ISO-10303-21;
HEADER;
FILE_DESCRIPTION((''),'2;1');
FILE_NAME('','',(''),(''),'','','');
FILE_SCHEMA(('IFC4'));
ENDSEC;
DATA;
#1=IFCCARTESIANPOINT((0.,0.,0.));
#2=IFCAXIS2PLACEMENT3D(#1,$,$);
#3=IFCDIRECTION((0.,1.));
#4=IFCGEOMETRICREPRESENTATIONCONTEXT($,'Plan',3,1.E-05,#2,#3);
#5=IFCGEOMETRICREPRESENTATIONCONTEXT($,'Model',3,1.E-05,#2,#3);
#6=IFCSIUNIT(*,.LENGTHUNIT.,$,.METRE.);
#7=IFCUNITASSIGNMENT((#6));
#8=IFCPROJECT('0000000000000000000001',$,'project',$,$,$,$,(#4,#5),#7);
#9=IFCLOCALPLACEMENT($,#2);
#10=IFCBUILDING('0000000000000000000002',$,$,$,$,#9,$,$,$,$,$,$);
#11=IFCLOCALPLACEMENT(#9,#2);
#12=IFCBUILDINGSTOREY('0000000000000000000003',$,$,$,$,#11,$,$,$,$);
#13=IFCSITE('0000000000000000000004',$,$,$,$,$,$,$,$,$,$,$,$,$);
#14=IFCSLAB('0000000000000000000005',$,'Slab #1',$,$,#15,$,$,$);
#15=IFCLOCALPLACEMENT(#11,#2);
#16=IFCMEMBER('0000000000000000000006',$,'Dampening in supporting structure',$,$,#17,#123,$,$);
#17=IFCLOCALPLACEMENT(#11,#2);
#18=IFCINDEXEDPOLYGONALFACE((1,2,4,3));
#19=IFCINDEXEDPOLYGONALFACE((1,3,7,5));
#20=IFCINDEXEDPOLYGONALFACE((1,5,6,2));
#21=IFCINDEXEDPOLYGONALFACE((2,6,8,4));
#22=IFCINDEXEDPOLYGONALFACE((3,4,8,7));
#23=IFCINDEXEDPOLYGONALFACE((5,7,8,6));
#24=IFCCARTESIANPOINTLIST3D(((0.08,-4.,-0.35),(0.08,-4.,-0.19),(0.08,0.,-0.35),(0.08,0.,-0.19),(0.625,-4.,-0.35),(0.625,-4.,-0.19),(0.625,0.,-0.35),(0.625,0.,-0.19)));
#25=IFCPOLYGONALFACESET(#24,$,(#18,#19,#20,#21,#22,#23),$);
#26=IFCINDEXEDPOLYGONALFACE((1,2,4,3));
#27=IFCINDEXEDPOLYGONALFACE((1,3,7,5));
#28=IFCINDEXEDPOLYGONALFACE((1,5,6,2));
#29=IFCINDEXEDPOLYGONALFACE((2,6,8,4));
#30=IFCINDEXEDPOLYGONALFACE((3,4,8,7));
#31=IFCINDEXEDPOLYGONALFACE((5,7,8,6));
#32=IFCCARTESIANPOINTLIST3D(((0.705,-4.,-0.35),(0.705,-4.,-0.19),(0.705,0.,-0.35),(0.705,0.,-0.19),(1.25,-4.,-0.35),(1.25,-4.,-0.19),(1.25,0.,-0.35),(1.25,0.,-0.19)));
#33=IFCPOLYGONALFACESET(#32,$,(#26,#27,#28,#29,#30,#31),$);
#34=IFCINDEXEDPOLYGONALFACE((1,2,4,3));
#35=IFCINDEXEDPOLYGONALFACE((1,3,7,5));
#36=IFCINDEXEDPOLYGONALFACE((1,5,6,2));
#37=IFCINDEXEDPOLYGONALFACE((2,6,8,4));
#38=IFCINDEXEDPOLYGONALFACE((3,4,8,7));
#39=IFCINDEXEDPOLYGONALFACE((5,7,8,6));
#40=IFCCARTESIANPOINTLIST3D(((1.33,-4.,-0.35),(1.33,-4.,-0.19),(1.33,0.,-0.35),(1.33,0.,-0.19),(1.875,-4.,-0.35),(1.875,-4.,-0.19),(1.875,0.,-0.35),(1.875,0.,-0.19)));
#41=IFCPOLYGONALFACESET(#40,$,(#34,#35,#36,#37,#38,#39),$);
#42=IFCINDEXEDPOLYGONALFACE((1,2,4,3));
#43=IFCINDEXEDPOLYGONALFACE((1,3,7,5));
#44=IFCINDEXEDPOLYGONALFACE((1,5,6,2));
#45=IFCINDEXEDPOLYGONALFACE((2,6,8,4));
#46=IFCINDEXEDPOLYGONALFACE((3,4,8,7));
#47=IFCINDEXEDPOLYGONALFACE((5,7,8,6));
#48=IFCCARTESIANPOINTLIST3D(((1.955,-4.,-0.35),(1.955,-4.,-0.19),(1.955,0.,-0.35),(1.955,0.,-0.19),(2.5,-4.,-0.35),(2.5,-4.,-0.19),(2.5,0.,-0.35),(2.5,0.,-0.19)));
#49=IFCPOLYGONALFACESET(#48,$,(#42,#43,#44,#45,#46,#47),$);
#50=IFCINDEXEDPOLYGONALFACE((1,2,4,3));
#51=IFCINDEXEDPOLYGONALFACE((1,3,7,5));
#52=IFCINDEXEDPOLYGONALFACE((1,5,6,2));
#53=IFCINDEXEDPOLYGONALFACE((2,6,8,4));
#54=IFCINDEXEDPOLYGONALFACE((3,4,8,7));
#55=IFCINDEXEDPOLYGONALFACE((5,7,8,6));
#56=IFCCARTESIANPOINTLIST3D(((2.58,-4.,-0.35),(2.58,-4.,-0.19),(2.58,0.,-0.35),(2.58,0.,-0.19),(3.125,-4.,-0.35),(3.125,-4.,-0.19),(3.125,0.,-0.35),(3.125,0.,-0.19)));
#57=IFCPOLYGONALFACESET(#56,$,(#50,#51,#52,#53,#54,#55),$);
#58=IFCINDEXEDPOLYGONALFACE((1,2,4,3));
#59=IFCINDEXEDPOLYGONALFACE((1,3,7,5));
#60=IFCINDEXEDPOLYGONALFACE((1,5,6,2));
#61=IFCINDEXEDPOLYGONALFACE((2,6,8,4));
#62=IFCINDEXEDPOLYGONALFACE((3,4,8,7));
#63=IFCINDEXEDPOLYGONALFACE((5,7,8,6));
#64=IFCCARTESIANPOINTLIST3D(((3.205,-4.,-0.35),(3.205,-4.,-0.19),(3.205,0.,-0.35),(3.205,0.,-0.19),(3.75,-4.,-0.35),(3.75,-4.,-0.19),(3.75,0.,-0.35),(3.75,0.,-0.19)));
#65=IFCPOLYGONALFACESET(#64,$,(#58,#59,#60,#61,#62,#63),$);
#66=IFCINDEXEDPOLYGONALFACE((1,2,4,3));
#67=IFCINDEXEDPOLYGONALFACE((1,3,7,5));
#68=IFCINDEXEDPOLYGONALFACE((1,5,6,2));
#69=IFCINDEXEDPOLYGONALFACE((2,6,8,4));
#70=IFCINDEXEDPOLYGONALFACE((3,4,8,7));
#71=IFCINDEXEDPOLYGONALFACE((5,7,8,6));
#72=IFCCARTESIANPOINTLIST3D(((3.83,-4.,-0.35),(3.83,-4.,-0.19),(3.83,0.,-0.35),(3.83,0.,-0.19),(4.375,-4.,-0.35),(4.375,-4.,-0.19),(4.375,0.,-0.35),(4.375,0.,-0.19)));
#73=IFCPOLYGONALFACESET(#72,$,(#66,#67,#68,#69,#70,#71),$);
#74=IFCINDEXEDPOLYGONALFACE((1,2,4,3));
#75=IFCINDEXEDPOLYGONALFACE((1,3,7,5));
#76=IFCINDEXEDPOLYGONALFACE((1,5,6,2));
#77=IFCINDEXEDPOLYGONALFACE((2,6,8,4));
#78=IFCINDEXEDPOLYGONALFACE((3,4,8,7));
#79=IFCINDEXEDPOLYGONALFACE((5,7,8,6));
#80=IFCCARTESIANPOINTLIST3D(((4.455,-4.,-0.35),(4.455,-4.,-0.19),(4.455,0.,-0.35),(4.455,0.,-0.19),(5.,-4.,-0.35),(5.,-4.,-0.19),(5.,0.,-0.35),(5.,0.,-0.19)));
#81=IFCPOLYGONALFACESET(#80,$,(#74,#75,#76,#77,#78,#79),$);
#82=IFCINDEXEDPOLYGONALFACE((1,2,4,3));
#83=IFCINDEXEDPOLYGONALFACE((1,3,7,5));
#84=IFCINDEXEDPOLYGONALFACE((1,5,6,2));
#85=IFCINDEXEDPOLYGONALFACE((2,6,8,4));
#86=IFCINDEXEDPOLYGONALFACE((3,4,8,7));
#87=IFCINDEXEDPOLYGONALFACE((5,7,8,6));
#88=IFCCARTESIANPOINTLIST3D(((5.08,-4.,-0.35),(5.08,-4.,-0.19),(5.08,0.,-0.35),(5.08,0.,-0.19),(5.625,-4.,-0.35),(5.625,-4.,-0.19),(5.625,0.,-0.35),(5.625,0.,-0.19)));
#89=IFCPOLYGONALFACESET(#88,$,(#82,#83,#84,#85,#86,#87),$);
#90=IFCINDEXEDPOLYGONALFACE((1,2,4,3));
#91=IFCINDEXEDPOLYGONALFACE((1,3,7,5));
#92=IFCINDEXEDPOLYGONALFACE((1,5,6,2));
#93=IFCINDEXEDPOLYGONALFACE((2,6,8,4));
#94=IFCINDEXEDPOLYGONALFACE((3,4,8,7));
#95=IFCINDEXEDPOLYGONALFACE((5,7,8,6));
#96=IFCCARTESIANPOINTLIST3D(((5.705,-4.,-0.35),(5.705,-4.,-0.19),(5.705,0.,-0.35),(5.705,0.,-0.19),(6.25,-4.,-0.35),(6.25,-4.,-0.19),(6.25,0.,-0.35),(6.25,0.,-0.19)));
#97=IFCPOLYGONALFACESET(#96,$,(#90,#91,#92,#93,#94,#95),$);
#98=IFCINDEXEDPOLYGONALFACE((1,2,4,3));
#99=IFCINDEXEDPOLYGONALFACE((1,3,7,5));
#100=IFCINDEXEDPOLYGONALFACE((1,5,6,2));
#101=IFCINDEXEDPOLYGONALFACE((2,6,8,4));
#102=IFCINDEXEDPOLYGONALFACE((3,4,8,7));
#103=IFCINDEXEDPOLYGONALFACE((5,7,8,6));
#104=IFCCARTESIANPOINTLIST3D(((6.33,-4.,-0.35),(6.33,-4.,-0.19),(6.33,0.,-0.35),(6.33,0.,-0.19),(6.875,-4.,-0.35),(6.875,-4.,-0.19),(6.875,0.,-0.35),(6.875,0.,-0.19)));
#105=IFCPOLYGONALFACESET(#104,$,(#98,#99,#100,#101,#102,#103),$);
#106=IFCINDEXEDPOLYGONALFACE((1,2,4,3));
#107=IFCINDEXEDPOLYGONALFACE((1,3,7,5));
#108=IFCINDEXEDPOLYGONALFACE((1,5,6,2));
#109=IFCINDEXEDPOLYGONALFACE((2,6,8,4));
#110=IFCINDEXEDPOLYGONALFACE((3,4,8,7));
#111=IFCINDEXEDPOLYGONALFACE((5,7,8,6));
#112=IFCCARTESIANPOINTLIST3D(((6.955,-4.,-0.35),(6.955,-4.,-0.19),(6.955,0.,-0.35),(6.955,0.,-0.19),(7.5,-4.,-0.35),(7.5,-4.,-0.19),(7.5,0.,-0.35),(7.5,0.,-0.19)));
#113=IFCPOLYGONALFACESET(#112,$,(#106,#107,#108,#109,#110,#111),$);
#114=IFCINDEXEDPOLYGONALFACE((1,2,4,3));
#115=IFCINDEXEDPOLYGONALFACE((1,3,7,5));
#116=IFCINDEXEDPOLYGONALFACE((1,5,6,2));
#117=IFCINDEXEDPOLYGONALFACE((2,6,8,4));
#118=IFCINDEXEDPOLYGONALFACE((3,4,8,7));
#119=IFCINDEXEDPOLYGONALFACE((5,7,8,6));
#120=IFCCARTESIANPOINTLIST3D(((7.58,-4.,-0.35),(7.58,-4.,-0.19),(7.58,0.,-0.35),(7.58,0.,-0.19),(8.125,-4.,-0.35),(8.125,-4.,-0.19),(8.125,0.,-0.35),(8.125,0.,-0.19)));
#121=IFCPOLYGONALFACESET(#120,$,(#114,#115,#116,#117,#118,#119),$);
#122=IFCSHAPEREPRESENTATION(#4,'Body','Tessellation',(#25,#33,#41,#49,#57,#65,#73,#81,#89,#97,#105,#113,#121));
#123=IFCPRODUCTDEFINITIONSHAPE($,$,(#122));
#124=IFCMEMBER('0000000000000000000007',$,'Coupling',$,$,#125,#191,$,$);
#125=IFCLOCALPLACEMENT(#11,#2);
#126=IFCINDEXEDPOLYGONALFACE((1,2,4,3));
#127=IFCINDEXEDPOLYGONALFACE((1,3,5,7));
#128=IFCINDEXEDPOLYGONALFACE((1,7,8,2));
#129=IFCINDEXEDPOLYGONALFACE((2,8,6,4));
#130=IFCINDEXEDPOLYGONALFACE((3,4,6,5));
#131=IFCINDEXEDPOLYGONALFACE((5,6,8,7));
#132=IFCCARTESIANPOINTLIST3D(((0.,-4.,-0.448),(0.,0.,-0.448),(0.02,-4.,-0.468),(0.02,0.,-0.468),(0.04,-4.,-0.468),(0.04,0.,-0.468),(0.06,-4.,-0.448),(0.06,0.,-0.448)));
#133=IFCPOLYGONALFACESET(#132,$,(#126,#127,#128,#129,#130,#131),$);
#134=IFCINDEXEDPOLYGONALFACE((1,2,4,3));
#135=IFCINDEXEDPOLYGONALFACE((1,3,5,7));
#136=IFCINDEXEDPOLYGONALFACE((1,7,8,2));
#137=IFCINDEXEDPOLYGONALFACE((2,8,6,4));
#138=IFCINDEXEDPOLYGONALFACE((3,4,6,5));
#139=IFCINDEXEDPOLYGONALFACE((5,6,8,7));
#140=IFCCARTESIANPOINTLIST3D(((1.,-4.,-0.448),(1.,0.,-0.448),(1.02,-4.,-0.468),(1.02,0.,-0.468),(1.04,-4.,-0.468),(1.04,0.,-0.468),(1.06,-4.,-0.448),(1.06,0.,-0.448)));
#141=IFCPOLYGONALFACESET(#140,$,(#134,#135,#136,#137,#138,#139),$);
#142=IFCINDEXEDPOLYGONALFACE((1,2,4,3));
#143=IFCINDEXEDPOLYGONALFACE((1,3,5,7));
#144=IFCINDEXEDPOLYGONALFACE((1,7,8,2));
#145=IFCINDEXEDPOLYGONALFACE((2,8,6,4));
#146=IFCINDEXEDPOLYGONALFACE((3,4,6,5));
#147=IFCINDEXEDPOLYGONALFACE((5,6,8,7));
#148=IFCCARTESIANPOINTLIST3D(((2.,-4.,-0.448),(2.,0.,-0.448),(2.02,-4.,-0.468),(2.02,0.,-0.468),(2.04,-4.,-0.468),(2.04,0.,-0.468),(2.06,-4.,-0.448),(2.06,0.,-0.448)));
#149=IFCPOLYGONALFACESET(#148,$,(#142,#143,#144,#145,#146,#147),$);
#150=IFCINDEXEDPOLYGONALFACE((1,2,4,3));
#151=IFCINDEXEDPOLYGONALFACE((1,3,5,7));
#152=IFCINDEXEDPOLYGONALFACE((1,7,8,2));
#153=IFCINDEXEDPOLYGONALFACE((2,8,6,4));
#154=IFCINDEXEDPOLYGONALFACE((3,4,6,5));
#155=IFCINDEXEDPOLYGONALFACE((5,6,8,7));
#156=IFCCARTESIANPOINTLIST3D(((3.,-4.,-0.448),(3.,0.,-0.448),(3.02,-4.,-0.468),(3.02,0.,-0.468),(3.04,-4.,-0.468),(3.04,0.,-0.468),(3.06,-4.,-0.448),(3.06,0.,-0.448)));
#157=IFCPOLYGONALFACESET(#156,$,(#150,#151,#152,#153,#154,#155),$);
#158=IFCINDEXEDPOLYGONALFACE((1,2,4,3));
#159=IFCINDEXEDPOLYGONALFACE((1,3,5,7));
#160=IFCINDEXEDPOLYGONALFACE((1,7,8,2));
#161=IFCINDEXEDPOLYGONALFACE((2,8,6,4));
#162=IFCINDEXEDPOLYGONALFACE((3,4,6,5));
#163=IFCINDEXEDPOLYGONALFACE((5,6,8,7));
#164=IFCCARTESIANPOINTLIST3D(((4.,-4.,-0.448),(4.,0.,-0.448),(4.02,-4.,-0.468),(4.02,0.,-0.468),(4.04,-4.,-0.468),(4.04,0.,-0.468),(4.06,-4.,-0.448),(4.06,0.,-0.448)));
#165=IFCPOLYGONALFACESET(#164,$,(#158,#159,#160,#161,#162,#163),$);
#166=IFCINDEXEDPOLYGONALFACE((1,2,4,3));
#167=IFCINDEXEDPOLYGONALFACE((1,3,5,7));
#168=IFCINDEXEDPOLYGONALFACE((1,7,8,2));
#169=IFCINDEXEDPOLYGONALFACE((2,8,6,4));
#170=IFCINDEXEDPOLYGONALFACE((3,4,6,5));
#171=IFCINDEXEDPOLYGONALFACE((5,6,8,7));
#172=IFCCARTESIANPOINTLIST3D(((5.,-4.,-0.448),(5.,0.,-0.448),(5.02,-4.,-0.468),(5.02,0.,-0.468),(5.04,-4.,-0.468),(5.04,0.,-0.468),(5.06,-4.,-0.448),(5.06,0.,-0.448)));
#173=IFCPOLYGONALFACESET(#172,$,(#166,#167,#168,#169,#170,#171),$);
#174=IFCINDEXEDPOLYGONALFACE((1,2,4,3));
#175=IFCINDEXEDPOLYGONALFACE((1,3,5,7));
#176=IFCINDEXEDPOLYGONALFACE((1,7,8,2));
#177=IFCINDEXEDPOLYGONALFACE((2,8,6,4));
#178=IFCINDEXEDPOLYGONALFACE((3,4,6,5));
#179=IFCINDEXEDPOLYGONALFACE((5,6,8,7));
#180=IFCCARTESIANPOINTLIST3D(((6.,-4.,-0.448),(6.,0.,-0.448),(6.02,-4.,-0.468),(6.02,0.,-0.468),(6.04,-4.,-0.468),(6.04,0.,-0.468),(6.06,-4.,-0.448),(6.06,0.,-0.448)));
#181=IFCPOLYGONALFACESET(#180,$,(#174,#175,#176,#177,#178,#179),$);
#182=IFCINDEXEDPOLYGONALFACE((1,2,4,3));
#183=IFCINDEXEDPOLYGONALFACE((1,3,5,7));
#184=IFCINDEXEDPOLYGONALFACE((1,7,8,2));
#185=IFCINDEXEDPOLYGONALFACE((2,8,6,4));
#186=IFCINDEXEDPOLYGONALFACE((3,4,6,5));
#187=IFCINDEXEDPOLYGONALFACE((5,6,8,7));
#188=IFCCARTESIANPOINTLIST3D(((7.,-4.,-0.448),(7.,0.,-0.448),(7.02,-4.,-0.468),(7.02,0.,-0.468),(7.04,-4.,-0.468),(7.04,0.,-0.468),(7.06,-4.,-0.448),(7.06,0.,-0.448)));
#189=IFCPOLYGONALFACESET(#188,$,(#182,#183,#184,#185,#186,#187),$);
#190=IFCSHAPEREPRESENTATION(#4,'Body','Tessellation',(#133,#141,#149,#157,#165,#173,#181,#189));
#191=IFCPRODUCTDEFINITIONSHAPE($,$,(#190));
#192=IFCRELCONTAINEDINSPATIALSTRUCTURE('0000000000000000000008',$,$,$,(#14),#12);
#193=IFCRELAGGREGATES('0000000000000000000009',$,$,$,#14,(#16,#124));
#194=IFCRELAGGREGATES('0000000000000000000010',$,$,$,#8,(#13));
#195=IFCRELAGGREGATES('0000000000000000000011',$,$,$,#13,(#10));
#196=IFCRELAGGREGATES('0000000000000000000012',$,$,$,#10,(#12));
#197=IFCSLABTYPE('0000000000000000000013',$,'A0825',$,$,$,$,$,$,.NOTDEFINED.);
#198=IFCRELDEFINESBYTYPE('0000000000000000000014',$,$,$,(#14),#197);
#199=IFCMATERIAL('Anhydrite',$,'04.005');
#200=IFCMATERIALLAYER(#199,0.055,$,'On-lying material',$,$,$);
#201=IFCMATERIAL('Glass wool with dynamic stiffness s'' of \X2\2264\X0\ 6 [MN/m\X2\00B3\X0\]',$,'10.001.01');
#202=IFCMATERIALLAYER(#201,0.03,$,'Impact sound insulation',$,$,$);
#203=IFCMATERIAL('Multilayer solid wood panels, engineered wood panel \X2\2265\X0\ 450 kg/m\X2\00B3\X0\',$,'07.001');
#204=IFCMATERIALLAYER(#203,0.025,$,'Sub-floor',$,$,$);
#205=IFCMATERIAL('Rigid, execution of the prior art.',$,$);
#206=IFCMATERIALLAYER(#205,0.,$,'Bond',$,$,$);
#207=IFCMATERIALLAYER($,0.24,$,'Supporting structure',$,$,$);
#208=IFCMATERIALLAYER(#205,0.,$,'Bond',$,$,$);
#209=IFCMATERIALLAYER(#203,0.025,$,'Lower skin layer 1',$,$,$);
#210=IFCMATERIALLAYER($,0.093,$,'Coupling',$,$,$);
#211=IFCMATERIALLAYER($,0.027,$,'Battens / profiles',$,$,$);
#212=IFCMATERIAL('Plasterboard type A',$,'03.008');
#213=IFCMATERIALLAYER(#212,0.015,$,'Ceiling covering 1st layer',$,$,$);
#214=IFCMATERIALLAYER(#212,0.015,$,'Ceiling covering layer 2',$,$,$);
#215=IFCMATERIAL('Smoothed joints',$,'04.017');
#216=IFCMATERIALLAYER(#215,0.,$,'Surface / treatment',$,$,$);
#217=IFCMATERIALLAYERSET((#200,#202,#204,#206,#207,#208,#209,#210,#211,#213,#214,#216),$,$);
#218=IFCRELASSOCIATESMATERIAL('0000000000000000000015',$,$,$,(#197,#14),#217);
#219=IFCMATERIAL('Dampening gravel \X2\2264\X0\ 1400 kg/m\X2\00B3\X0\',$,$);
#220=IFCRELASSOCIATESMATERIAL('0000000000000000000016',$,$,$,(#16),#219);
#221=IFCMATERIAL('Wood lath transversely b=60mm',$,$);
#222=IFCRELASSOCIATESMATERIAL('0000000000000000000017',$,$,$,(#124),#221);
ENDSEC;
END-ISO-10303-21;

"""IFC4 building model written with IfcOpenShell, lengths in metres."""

from ifc_helpers import new_model, si_unit, direction, frame, frame_2d, origin, place, context, project, spatial, polyline, rectangle, outline, extrude, material, layer, layer_set, type_object, element, aggregate, save


model = new_model("IFC4")

# Units and contexts
plan_context = context("Plan", 3, precision=1e-05, world=origin(), true_north=direction((0.0, 1.0)))
model_context = context("Model", 3, precision=1e-05, world=origin(), true_north=direction((0.0, 1.0)))
ifc_project = project(units=[si_unit("LENGTHUNIT", "METRE")], contexts=[plan_context, model_context])

# Site, building, storey
site = spatial("IfcSite", under=ifc_project)
building_placement = place(None, origin())
building = spatial("IfcBuilding", under=site, at=building_placement)
storey_placement = place(building_placement, origin())
storey = spatial("IfcBuildingStorey", under=building, at=storey_placement)

# Slab, members
ifc_material_1 = material(Name="Anhydrite", Category="04.005")
ifc_layer_1 = layer(ifc_material_1, 0.055, Name="On-lying material")
ifc_material_2 = material(Name="Glass wool with dynamic stiffness s' of ≤ 6 [MN/m³]", Category="10.001.01")
ifc_layer_2 = layer(ifc_material_2, 0.03, Name="Impact sound insulation")
ifc_material_3 = material(Name="Multilayer solid wood panels, engineered wood panel ≥ 450 kg/m³", Category="07.001")
ifc_layer_3 = layer(ifc_material_3, 0.025, Name="Sub-floor")
ifc_material_4 = material(Name="Rigid, execution of the prior art.")
ifc_layer_4 = layer(ifc_material_4, 0.0, Name="Bond")
ifc_layer_5 = layer(None, 0.24, Name="Supporting structure")
ifc_layer_6 = layer(ifc_material_4, 0.0, Name="Bond")
ifc_layer_7 = layer(ifc_material_3, 0.025, Name="Lower skin layer 1")
ifc_layer_8 = layer(None, 0.093, Name="Coupling")
ifc_layer_9 = layer(None, 0.027, Name="Battens / profiles")
ifc_material_5 = material(Name="Plasterboard type A", Category="03.008")
ifc_layer_10 = layer(ifc_material_5, 0.015, Name="Ceiling covering 1st layer")
ifc_layer_11 = layer(ifc_material_5, 0.015, Name="Ceiling covering layer 2")
ifc_material_6 = material(Name="Smoothed joints", Category="04.017")
ifc_layer_12 = layer(ifc_material_6, 0.0, Name="Surface / treatment")
ifc_layer_set = layer_set([ifc_layer_1, ifc_layer_2, ifc_layer_3, ifc_layer_4, ifc_layer_5, ifc_layer_6, ifc_layer_7, ifc_layer_8, ifc_layer_9, ifc_layer_10, ifc_layer_11, ifc_layer_12])
slab_type = type_object("IfcSlabType", Name="A0825", PredefinedType="NOTDEFINED", material=ifc_layer_set)
slab_placement = place(None, frame((0.0, 0.0, 0.0), z_axis=(0.0, 0.0, -1.0), x_axis=(1.0, 0.0, 0.0)))
slab = element("IfcSlab", 1, at=slab_placement, inside=storey, type_object=slab_type, material=ifc_layer_set, Name="Slab #1")
ifc_material_7 = material(Name="Dampening gravel ≤ 1400 kg/m³")
member_1_placement = place(slab_placement, origin())
member_1 = element("IfcMember", 2, at=member_1_placement, material=ifc_material_7, Name="Dampening in supporting structure", context=plan_context, shape_type="SweptSolid", body=[
    extrude(rectangle(XDim=0.545, YDim=0.16, at=frame_2d((0.2725, 0.08), x_axis=(1.0, 0.0))), frame((0.08, 4.0, 0.19), z_axis=(0.0, -1.0, 0.0), x_axis=(1.0, 0.0, 0.0)), (0.0, 0.0, 1.0), 4.0),
    extrude(rectangle(XDim=0.545, YDim=0.16, at=frame_2d((0.2725, 0.08), x_axis=(1.0, 0.0))), frame((0.705, 4.0, 0.19), z_axis=(0.0, -1.0, 0.0), x_axis=(1.0, 0.0, 0.0)), (0.0, 0.0, 1.0), 4.0),
    extrude(rectangle(XDim=0.545, YDim=0.16, at=frame_2d((0.2725, 0.08), x_axis=(1.0, 0.0))), frame((1.33, 4.0, 0.19), z_axis=(0.0, -1.0, 0.0), x_axis=(1.0, 0.0, 0.0)), (0.0, 0.0, 1.0), 4.0),
    extrude(rectangle(XDim=0.545, YDim=0.16, at=frame_2d((0.2725, 0.08), x_axis=(1.0, 0.0))), frame((1.955, 4.0, 0.19), z_axis=(0.0, -1.0, 0.0), x_axis=(1.0, 0.0, 0.0)), (0.0, 0.0, 1.0), 4.0),
    extrude(rectangle(XDim=0.545, YDim=0.16, at=frame_2d((0.2725, 0.08), x_axis=(1.0, 0.0))), frame((2.58, 4.0, 0.19), z_axis=(0.0, -1.0, 0.0), x_axis=(1.0, 0.0, 0.0)), (0.0, 0.0, 1.0), 4.0),
    extrude(rectangle(XDim=0.545, YDim=0.16, at=frame_2d((0.2725, 0.08), x_axis=(1.0, 0.0))), frame((3.205, 4.0, 0.19), z_axis=(0.0, -1.0, 0.0), x_axis=(1.0, 0.0, 0.0)), (0.0, 0.0, 1.0), 4.0),
    extrude(rectangle(XDim=0.545, YDim=0.16, at=frame_2d((0.2725, 0.08), x_axis=(1.0, 0.0))), frame((3.83, 4.0, 0.19), z_axis=(0.0, -1.0, 0.0), x_axis=(1.0, 0.0, 0.0)), (0.0, 0.0, 1.0), 4.0),
    extrude(rectangle(XDim=0.545, YDim=0.16, at=frame_2d((0.2725, 0.08), x_axis=(1.0, 0.0))), frame((4.455, 4.0, 0.19), z_axis=(0.0, -1.0, 0.0), x_axis=(1.0, 0.0, 0.0)), (0.0, 0.0, 1.0), 4.0),
    extrude(rectangle(XDim=0.545, YDim=0.16, at=frame_2d((0.2725, 0.08), x_axis=(1.0, 0.0))), frame((5.08, 4.0, 0.19), z_axis=(0.0, -1.0, 0.0), x_axis=(1.0, 0.0, 0.0)), (0.0, 0.0, 1.0), 4.0),
    extrude(rectangle(XDim=0.545, YDim=0.16, at=frame_2d((0.2725, 0.08), x_axis=(1.0, 0.0))), frame((5.705, 4.0, 0.19), z_axis=(0.0, -1.0, 0.0), x_axis=(1.0, 0.0, 0.0)), (0.0, 0.0, 1.0), 4.0),
    extrude(rectangle(XDim=0.545, YDim=0.16, at=frame_2d((0.2725, 0.08), x_axis=(1.0, 0.0))), frame((6.33, 4.0, 0.19), z_axis=(0.0, -1.0, 0.0), x_axis=(1.0, 0.0, 0.0)), (0.0, 0.0, 1.0), 4.0),
    extrude(rectangle(XDim=0.545, YDim=0.16, at=frame_2d((0.2725, 0.08), x_axis=(1.0, 0.0))), frame((6.955, 4.0, 0.19), z_axis=(0.0, -1.0, 0.0), x_axis=(1.0, 0.0, 0.0)), (0.0, 0.0, 1.0), 4.0),
    extrude(rectangle(XDim=0.545, YDim=0.16, at=frame_2d((0.2725, 0.08), x_axis=(1.0, 0.0))), frame((7.58, 4.0, 0.19), z_axis=(0.0, -1.0, 0.0), x_axis=(1.0, 0.0, 0.0)), (0.0, 0.0, 1.0), 4.0),
])
ifc_material_8 = material(Name="Wood lath transversely b=60mm")
member_2_placement = place(slab_placement, origin())
member_2 = element("IfcMember", 3, at=member_2_placement, material=ifc_material_8, Name="Coupling", context=plan_context, shape_type="SweptSolid", body=[
    extrude(outline(polyline([(0.0, 0.0), (0.06, 0.0), (0.04, 0.02), (0.02, 0.02), (0.0, 0.0)])), frame((0.0, 4.0, 0.448), z_axis=(0.0, -1.0, 0.0), x_axis=(1.0, 0.0, 0.0)), (0.0, 0.0, 1.0), 4.0),
    extrude(outline(polyline([(0.0, 0.0), (0.06, 0.0), (0.04, 0.02), (0.02, 0.02), (0.0, 0.0)])), frame((1.0, 4.0, 0.448), z_axis=(0.0, -1.0, 0.0), x_axis=(1.0, 0.0, 0.0)), (0.0, 0.0, 1.0), 4.0),
    extrude(outline(polyline([(0.0, 0.0), (0.06, 0.0), (0.04, 0.02), (0.02, 0.02), (0.0, 0.0)])), frame((2.0, 4.0, 0.448), z_axis=(0.0, -1.0, 0.0), x_axis=(1.0, 0.0, 0.0)), (0.0, 0.0, 1.0), 4.0),
    extrude(outline(polyline([(0.0, 0.0), (0.06, 0.0), (0.04, 0.02), (0.02, 0.02), (0.0, 0.0)])), frame((3.0, 4.0, 0.448), z_axis=(0.0, -1.0, 0.0), x_axis=(1.0, 0.0, 0.0)), (0.0, 0.0, 1.0), 4.0),
    extrude(outline(polyline([(0.0, 0.0), (0.06, 0.0), (0.04, 0.02), (0.02, 0.02), (0.0, 0.0)])), frame((4.0, 4.0, 0.448), z_axis=(0.0, -1.0, 0.0), x_axis=(1.0, 0.0, 0.0)), (0.0, 0.0, 1.0), 4.0),
    extrude(outline(polyline([(0.0, 0.0), (0.06, 0.0), (0.04, 0.02), (0.02, 0.02), (0.0, 0.0)])), frame((5.0, 4.0, 0.448), z_axis=(0.0, -1.0, 0.0), x_axis=(1.0, 0.0, 0.0)), (0.0, 0.0, 1.0), 4.0),
    extrude(outline(polyline([(0.0, 0.0), (0.06, 0.0), (0.04, 0.02), (0.02, 0.02), (0.0, 0.0)])), frame((6.0, 4.0, 0.448), z_axis=(0.0, -1.0, 0.0), x_axis=(1.0, 0.0, 0.0)), (0.0, 0.0, 1.0), 4.0),
    extrude(outline(polyline([(0.0, 0.0), (0.06, 0.0), (0.04, 0.02), (0.02, 0.02), (0.0, 0.0)])), frame((7.0, 4.0, 0.448), z_axis=(0.0, -1.0, 0.0), x_axis=(1.0, 0.0, 0.0)), (0.0, 0.0, 1.0), 4.0),
])
aggregate(slab, [member_1, member_2])

save(model, "model.ifc")
